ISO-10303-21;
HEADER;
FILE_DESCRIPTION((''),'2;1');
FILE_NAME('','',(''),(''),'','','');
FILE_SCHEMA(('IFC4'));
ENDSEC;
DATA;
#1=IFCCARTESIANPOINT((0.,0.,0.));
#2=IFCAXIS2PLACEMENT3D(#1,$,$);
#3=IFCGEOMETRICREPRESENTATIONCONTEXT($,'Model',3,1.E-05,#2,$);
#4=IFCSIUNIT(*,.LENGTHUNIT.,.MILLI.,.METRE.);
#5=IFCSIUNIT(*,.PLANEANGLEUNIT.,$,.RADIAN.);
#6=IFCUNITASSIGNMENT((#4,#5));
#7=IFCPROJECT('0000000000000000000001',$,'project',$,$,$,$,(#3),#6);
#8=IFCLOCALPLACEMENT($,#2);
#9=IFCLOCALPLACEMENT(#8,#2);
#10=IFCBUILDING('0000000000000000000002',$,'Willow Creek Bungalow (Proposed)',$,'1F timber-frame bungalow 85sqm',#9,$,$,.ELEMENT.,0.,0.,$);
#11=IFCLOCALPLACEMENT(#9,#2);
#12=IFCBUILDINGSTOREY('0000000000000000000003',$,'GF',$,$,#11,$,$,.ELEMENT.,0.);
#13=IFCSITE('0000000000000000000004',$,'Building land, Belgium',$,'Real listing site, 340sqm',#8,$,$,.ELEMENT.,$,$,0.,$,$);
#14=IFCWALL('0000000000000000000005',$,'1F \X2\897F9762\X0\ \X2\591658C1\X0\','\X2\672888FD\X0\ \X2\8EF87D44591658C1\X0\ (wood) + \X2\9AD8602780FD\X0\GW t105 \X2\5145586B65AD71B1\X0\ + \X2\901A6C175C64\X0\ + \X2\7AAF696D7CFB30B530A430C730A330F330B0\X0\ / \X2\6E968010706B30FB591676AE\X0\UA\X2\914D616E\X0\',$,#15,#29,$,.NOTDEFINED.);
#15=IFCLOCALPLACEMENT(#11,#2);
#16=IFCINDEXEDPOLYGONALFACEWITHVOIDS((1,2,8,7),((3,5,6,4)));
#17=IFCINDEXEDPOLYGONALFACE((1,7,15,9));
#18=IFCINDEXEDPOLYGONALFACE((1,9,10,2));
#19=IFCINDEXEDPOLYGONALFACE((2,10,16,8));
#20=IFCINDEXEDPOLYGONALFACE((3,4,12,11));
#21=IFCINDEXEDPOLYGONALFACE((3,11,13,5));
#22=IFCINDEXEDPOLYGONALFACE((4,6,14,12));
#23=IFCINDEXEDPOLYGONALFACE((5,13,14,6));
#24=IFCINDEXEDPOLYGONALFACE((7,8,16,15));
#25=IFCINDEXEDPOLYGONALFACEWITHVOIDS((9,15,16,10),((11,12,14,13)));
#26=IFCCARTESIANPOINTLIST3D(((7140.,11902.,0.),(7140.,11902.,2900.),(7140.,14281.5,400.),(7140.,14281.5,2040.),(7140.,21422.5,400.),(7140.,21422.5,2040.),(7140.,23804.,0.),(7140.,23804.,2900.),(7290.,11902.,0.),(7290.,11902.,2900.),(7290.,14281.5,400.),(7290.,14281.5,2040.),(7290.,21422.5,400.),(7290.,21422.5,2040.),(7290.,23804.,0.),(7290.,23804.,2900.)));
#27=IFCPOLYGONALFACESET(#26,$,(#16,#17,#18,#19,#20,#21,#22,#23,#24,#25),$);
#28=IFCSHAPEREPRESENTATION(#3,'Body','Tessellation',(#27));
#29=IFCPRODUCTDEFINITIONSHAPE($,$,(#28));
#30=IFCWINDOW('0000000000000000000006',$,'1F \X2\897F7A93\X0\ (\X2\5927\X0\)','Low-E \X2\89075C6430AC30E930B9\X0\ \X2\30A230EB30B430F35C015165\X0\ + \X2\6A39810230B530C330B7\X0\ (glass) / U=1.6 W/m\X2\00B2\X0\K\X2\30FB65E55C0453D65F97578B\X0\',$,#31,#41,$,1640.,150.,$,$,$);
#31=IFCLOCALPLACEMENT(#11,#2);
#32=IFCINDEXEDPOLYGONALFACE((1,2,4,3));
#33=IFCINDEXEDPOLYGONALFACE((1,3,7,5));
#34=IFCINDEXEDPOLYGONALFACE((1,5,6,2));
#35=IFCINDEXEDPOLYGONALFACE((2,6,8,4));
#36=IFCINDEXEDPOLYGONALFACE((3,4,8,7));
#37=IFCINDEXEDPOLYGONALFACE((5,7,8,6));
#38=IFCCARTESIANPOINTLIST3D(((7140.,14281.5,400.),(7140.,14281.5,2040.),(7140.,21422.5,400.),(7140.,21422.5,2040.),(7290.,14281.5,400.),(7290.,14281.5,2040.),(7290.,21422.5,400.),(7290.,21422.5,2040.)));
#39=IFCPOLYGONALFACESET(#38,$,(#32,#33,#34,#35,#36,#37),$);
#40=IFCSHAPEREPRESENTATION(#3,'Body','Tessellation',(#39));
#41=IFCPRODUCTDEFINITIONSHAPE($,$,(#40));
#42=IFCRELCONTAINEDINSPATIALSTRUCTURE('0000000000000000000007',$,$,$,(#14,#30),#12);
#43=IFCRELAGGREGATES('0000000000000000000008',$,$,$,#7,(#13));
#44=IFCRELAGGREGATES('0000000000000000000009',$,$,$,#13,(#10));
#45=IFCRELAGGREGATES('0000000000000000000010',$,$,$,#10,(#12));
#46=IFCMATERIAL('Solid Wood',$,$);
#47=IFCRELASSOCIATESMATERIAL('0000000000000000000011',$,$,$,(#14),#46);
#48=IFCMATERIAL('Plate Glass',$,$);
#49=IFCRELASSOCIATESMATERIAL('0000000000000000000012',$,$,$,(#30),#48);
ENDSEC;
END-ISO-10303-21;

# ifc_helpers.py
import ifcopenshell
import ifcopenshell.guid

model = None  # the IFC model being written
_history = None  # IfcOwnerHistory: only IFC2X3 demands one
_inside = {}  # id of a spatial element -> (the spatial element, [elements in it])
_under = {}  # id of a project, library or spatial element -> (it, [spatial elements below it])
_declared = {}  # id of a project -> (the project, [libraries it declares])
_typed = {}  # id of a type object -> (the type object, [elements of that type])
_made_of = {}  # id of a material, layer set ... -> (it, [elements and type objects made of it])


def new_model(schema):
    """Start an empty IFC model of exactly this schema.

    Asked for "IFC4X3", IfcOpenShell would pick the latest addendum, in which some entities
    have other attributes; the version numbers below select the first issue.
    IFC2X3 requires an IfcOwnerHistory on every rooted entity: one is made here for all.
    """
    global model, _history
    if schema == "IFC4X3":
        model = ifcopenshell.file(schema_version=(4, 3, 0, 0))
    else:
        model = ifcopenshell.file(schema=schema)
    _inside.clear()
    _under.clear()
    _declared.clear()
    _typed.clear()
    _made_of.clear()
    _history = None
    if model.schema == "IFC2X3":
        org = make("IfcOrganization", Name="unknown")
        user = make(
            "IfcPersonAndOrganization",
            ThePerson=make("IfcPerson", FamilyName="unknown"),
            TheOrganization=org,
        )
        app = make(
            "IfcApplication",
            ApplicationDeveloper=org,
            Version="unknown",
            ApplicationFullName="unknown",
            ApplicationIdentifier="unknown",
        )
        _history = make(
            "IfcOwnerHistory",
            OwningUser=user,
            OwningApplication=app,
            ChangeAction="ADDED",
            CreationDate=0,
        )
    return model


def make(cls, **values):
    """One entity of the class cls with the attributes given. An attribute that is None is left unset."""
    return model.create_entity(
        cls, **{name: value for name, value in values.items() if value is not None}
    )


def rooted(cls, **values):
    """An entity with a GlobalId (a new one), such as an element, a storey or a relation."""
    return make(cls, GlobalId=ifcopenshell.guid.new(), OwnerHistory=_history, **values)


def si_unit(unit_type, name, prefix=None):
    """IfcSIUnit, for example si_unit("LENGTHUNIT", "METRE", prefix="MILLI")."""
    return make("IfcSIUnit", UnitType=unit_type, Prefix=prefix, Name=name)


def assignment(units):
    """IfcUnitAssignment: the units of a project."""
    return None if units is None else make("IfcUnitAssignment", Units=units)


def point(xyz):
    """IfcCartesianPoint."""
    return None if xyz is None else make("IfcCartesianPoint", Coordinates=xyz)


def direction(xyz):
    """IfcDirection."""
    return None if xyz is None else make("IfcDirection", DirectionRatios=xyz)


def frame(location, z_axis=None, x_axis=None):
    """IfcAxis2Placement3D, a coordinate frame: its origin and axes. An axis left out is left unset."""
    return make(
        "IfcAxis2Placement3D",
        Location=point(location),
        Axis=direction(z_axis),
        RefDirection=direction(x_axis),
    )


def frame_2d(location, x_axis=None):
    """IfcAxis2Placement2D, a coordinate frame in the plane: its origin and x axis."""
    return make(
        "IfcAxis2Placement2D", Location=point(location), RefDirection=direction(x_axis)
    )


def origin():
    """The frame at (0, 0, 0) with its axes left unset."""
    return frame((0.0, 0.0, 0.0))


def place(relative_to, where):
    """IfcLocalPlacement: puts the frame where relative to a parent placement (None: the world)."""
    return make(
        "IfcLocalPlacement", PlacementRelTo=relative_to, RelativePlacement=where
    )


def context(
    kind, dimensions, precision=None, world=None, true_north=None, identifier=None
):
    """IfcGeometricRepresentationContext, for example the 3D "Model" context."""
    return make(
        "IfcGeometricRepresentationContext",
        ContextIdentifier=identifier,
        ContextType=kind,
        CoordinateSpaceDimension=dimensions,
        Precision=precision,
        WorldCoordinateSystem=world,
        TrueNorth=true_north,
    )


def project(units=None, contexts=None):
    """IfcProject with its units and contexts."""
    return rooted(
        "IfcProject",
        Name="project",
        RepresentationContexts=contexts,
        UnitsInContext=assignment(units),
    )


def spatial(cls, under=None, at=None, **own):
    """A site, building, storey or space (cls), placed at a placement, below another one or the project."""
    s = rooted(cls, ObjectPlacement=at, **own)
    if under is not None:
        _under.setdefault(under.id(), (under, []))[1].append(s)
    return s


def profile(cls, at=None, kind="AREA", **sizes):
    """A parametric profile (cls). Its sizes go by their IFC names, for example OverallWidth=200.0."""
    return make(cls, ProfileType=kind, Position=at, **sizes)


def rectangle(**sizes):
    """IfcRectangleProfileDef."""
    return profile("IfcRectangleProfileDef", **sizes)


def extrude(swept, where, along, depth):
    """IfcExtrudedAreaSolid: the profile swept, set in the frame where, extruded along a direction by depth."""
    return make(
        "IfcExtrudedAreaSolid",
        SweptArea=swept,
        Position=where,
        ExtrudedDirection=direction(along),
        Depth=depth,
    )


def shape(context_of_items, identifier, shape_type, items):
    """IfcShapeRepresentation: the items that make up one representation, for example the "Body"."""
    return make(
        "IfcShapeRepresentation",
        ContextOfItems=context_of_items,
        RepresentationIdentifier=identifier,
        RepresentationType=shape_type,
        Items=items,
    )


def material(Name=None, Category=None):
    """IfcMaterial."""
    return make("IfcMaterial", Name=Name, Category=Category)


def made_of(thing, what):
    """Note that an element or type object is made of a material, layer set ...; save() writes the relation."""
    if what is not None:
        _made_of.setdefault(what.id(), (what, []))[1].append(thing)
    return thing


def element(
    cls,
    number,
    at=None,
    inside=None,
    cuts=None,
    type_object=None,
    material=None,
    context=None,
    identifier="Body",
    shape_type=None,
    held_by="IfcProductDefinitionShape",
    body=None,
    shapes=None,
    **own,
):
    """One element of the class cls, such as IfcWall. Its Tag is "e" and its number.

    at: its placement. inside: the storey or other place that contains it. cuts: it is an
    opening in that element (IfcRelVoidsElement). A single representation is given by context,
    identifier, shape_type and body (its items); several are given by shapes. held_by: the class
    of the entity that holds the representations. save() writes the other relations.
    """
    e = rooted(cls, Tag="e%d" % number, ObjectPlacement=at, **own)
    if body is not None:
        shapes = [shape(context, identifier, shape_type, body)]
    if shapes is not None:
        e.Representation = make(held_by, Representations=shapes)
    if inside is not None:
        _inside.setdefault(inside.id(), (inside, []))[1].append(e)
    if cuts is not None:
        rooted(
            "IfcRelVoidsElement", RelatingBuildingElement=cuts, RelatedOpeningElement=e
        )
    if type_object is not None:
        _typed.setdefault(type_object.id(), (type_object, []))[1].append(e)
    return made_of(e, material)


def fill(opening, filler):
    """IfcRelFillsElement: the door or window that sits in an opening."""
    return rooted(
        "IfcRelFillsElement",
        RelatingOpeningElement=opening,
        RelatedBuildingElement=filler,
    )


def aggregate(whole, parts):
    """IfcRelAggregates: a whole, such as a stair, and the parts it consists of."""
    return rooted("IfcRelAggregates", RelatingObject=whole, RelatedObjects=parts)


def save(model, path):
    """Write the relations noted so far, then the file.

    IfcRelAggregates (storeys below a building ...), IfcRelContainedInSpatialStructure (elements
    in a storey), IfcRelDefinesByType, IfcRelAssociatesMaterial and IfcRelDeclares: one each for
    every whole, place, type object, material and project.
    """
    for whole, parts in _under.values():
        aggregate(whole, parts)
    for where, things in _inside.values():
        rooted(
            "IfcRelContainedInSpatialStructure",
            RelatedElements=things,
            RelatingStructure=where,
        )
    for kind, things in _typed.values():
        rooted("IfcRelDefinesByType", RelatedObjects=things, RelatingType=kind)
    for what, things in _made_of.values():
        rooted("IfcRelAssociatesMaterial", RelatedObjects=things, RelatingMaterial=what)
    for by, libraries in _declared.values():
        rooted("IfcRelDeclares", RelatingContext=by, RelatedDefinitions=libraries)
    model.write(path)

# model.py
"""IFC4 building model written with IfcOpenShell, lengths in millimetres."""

from ifc_helpers import new_model, si_unit, frame, frame_2d, origin, place, context, project, spatial, rectangle, extrude, material, element, fill, save


model = new_model("IFC4")

# Units and contexts
model_context = context("Model", 3, precision=1e-05, world=origin())
ifc_project = project(units=[si_unit("LENGTHUNIT", "METRE", prefix="MILLI"), si_unit("PLANEANGLEUNIT", "RADIAN")], contexts=[model_context])

# Site, building, storey
site_placement = place(None, origin())
site = spatial("IfcSite", under=ifc_project, at=site_placement, Name="Building land, Belgium", ObjectType="Real listing site, 340sqm", CompositionType="ELEMENT", RefElevation=0.0)
building_placement = place(site_placement, origin())
building = spatial("IfcBuilding", under=site, at=building_placement, Name="Willow Creek Bungalow (Proposed)", ObjectType="1F timber-frame bungalow 85sqm", CompositionType="ELEMENT", ElevationOfRefHeight=0.0, ElevationOfTerrain=0.0)
storey_placement = place(building_placement, origin())
storey = spatial("IfcBuildingStorey", under=building, at=storey_placement, Name="GF", CompositionType="ELEMENT", Elevation=0.0)

# Shared definitions
ifc_material_1 = material(Name="Solid Wood")

# Shared definitions
ifc_material_2 = material(Name="Plate Glass")

# Wall, opening, window
wall_1_placement = place(storey_placement, frame((3570.0, 5951.0, 0.0)))
wall_1 = element("IfcWall", 1, at=wall_1_placement, inside=storey, material=ifc_material_1, Name="1F 西面 外壁", Description="木製 軸組外壁 (wood) + 高性能GW t105 充填断熱 + 通気層 + 窯業系サイディング / 準耐火・外皮UA配慮", PredefinedType="NOTDEFINED", context=model_context, shape_type="SweptSolid", body=[
    extrude(rectangle(XDim=150.0, YDim=11902.0, at=frame_2d((75.0, 5951.0))), frame((3570.0, 5951.0, 0.0)), (0.0, 0.0, 1.0), 2900.0),
])
opening_1_placement = place(storey_placement, frame((3570.0, 7141.0, 200.0)))
opening_1 = element("IfcOpeningElement", 2, at=opening_1_placement, cuts=wall_1, PredefinedType="NOTDEFINED", context=model_context, shape_type="SweptSolid", body=[
    extrude(rectangle(XDim=150.0, YDim=7141.0, at=frame_2d((75.0, 3570.0))), frame((3570.0, 7141.0, 200.0)), (0.0, 0.0, 1.0), 1640.0),
])
window_1_placement = place(storey_placement, frame((3570.0, 7141.0, 200.0)))
window_1 = element("IfcWindow", 3, at=window_1_placement, inside=storey, material=ifc_material_2, Name="1F 西窓 (大)", Description="Low-E 複層ガラス アルゴン封入 + 樹脂サッシ (glass) / U=1.6 W/m²K・日射取得型", OverallHeight=1640.0, OverallWidth=150.0, context=model_context, shape_type="SweptSolid", body=[
    extrude(rectangle(XDim=150.0, YDim=7141.0, at=frame_2d((75.0, 3570.0))), frame((3570.0, 7141.0, 200.0)), (0.0, 0.0, 1.0), 1640.0),
])
fill(opening_1, window_1)

save(model, "model.ifc")
